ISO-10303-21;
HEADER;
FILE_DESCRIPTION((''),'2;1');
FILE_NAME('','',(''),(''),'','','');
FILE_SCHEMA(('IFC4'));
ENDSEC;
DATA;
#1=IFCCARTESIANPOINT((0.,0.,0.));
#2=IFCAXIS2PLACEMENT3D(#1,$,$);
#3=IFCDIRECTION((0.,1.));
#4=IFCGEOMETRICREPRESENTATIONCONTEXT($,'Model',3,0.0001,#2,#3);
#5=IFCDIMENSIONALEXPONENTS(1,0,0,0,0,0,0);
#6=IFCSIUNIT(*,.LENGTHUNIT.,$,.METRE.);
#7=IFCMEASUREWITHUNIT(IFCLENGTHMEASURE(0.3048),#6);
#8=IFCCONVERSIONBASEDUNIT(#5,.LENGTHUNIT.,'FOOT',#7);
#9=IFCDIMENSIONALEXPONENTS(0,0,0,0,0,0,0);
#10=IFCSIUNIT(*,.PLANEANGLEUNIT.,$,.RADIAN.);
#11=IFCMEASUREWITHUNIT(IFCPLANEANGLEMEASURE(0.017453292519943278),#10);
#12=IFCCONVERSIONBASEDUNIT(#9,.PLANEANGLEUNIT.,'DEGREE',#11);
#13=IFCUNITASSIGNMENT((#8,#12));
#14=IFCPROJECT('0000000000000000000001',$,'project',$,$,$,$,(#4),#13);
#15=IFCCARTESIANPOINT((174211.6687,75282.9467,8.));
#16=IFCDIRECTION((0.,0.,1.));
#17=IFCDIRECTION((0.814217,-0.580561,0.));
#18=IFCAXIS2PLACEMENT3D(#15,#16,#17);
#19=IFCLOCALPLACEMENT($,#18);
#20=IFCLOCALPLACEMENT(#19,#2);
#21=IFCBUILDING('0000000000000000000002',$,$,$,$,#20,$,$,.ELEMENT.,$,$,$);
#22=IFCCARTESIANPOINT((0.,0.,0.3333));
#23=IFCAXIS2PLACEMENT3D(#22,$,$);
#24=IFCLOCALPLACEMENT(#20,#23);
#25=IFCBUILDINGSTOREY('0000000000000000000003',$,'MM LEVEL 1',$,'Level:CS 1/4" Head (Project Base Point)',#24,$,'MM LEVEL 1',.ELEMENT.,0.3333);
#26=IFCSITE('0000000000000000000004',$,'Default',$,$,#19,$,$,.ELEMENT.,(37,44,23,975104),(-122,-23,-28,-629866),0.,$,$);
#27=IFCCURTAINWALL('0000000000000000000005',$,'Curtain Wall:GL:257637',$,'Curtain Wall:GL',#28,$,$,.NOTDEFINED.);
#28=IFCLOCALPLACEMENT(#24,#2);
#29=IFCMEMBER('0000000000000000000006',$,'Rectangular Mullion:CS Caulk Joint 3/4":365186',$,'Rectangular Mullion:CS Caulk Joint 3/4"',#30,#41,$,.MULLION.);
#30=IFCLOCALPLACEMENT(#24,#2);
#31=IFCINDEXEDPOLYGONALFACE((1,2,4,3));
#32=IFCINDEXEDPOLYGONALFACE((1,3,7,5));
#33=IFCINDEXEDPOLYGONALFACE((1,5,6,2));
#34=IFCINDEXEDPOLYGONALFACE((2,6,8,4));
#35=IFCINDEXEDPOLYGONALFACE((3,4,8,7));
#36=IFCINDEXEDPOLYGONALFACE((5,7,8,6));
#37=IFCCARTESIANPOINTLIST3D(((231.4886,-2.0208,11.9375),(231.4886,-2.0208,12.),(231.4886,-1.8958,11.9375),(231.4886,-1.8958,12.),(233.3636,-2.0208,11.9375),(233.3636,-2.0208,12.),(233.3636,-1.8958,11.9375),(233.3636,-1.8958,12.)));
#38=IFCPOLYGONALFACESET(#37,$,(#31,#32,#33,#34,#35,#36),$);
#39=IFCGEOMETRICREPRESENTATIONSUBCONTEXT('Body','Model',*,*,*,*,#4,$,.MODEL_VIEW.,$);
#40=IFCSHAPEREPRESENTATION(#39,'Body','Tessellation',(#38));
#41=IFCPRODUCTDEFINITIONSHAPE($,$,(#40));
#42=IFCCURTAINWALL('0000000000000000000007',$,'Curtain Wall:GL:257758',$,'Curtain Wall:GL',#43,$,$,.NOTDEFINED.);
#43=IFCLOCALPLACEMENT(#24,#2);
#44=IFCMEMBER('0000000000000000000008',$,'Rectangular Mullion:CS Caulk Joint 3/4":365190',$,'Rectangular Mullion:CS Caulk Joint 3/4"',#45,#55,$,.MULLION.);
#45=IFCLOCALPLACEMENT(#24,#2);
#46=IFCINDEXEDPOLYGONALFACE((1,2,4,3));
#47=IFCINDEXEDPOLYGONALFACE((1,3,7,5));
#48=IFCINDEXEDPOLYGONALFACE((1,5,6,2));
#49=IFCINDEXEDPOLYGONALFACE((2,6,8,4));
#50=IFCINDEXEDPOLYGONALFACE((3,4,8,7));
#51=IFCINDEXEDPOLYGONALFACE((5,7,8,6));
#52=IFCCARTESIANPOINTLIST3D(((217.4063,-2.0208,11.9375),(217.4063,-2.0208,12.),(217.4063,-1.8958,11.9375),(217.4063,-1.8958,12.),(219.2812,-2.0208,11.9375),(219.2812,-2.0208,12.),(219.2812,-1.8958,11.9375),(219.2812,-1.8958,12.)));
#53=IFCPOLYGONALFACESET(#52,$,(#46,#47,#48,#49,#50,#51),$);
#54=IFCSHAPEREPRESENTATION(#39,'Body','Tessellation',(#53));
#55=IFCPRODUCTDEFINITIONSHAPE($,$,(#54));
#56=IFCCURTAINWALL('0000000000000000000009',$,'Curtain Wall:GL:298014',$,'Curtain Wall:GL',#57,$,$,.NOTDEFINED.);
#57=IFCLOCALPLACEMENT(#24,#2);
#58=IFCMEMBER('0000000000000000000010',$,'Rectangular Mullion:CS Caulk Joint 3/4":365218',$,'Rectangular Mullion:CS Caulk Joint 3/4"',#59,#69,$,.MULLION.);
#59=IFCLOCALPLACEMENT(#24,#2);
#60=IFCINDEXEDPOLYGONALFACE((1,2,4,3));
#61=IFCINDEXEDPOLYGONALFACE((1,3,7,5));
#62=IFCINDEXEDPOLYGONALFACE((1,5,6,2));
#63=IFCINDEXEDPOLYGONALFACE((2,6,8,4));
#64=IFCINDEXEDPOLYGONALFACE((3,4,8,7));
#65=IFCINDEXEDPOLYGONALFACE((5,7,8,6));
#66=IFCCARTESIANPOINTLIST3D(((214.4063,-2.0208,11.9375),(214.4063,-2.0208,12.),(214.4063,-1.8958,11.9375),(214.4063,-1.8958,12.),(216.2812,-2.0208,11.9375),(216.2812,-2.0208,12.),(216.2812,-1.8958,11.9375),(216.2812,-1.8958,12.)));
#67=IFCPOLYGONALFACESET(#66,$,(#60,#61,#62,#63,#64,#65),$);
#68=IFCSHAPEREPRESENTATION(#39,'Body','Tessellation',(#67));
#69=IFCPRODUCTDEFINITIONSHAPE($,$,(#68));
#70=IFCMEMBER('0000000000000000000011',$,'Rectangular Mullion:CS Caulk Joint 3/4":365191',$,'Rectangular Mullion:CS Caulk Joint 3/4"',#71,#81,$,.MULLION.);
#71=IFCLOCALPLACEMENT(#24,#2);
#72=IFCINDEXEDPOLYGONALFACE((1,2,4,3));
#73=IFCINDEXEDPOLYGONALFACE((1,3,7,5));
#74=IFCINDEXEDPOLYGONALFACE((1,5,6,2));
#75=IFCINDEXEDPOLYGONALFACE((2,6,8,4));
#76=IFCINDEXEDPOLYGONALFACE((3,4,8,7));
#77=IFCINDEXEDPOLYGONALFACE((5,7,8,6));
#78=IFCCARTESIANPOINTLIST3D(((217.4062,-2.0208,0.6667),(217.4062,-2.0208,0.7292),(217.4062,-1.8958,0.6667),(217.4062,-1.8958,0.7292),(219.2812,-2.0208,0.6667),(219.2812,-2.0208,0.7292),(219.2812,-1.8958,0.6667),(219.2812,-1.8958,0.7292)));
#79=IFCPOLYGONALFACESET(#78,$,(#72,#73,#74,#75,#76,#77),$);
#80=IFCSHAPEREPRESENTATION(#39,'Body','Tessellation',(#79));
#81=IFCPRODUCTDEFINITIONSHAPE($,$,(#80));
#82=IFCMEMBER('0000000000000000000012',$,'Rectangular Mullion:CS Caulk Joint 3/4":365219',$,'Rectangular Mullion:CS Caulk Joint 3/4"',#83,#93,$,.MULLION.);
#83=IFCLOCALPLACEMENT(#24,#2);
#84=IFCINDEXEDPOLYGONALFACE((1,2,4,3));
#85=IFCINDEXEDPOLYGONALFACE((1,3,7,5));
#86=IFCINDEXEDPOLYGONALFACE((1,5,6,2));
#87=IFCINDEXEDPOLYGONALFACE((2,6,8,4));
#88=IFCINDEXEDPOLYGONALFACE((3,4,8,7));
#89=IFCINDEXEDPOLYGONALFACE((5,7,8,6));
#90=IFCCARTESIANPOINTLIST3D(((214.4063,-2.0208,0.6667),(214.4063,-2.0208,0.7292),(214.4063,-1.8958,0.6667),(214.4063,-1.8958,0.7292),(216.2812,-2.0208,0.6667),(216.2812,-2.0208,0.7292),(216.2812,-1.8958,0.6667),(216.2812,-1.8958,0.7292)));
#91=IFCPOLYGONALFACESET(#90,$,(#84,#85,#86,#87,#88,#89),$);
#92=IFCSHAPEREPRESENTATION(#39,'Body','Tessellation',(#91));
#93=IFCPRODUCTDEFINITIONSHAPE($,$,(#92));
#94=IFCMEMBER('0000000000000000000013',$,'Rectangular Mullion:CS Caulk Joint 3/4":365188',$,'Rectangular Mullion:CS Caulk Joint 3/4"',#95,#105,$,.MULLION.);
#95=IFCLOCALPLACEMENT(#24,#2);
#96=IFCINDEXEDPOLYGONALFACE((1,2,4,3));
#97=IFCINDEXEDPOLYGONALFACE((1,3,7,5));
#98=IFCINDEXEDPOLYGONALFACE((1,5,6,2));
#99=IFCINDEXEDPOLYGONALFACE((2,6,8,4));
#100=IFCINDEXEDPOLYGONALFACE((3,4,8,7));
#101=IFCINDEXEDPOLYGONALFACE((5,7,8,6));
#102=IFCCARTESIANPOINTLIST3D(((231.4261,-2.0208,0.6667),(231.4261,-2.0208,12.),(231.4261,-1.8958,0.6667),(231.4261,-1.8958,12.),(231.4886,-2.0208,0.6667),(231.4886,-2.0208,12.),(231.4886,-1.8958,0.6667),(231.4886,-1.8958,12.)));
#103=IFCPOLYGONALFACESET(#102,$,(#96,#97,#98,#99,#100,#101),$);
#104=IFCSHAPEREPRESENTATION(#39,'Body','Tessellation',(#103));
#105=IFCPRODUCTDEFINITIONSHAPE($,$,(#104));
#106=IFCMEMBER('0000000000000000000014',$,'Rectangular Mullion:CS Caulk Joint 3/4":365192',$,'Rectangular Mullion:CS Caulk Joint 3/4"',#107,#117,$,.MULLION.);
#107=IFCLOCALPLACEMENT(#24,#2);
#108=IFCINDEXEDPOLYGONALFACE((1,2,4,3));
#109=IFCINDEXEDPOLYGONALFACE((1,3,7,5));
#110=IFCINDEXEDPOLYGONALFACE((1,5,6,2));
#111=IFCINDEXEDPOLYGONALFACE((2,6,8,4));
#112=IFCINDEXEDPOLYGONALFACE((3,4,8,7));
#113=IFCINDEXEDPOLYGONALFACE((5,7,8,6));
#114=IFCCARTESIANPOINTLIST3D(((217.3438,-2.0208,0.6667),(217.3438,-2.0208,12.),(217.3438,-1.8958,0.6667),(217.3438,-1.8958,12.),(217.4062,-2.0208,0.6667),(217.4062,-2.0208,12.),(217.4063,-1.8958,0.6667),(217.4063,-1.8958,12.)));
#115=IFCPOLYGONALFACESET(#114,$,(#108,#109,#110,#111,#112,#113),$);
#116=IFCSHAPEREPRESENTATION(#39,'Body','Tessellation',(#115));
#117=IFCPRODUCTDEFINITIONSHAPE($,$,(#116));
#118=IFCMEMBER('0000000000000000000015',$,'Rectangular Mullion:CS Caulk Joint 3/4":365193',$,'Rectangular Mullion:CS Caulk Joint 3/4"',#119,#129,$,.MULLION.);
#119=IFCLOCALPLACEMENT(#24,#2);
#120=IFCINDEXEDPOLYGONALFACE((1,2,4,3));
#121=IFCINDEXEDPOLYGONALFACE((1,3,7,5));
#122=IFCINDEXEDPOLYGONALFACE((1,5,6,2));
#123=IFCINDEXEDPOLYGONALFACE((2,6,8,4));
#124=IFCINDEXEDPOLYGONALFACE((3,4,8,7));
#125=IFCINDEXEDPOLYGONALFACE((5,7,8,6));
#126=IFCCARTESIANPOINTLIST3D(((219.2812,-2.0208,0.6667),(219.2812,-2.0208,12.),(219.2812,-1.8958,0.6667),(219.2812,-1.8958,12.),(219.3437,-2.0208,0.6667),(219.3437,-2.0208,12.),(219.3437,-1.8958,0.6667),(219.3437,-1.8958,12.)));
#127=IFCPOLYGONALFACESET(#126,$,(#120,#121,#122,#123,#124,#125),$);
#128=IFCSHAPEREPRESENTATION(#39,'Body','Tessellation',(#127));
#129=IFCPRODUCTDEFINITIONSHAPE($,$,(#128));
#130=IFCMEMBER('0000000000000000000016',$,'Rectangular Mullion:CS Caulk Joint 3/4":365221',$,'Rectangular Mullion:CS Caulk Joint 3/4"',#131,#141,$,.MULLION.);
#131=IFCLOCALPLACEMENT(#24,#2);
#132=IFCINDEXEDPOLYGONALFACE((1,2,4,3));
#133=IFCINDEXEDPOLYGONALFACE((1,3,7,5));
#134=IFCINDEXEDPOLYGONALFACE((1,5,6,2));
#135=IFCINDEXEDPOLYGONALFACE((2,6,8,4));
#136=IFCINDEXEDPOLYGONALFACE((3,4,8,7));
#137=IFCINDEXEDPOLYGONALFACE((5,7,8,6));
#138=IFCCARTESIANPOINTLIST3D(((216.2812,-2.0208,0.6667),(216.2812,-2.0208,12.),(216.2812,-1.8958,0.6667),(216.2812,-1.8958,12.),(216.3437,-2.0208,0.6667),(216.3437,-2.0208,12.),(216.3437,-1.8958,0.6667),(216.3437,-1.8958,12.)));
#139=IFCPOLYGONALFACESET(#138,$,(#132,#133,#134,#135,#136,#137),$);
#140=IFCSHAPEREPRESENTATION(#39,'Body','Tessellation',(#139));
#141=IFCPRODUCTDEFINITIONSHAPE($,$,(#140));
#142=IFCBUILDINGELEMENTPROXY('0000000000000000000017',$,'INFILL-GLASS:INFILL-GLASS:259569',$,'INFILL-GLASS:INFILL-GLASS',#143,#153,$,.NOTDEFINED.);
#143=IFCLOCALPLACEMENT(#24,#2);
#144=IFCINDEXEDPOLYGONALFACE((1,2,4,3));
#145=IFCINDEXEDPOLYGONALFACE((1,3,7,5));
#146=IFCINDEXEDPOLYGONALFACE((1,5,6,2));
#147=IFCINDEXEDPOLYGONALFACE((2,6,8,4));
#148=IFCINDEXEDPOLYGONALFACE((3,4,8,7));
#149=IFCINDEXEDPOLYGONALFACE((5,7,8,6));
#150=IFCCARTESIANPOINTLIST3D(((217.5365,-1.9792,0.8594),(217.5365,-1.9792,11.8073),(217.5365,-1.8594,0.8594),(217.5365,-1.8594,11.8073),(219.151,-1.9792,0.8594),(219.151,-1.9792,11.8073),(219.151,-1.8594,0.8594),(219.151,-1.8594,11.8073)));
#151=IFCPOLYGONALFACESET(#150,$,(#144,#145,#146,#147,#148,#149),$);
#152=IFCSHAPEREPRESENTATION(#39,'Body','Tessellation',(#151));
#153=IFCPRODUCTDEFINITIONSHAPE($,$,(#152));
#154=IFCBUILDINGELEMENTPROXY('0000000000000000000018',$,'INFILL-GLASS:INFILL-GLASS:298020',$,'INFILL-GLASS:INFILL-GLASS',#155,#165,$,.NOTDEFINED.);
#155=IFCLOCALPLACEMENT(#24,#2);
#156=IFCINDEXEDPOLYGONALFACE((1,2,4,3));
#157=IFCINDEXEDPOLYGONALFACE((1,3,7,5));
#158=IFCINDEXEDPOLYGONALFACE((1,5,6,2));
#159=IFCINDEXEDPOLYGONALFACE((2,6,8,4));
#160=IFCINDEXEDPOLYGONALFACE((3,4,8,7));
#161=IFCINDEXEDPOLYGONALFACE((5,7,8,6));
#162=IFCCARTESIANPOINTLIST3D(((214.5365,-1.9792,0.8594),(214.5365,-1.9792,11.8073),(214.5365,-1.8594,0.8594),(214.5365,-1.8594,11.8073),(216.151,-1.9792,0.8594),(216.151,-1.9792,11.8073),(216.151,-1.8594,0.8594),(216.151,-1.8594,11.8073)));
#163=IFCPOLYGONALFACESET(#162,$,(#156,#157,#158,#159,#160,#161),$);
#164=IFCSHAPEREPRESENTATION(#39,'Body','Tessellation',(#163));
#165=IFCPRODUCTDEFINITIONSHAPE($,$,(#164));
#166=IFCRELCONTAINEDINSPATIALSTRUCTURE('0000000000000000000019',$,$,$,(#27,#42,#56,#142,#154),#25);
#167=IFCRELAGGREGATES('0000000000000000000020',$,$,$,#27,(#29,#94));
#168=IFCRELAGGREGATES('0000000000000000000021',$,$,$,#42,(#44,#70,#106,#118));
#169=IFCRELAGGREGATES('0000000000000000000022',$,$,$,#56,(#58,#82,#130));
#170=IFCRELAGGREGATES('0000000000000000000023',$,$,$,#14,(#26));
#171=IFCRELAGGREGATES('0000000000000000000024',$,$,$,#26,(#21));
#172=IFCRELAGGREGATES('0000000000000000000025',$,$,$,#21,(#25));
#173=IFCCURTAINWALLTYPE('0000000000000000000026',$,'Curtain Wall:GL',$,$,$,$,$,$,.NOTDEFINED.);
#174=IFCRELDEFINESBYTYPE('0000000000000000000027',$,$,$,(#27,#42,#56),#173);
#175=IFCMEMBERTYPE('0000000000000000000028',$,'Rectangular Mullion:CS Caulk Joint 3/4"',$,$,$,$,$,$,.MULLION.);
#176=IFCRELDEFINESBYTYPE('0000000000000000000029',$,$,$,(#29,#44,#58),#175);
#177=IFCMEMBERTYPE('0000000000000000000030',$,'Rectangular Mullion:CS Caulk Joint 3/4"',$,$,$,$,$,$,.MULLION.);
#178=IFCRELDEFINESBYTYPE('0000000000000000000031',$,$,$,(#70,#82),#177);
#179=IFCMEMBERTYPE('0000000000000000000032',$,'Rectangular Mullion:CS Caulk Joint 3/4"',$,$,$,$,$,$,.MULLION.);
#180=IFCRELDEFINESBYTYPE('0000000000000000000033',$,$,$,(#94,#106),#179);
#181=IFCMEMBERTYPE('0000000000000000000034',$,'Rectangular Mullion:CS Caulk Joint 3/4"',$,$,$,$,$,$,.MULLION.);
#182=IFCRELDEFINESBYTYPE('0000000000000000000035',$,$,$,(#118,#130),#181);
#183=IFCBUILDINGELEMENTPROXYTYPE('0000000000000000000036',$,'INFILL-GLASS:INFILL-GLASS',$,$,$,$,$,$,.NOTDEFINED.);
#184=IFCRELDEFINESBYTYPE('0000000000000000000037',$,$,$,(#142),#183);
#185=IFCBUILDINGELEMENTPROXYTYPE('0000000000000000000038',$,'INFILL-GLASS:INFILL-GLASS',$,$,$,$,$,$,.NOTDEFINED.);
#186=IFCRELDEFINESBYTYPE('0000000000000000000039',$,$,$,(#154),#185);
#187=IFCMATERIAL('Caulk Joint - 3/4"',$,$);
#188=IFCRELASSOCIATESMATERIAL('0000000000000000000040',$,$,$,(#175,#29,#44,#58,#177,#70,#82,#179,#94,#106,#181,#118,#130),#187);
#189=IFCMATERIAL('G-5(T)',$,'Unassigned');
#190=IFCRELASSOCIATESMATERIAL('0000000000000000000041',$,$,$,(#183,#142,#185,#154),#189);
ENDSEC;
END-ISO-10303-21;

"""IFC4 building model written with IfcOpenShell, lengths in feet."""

from ifc_helpers import new_model, entity, si_unit, converted_unit, direction, frame, origin, place, context, subcontext, project, spatial, indexed_curve, outline, extrude, source, transform, mapped, material, type_object, type_shapes, element, aggregate, save


model = new_model("IFC4")

# Units and contexts
model_context = context("Model", 3, precision=0.0001, world=origin(), true_north=direction((0.0, 1.0)))
body_context = subcontext(model_context, "Body", "Model", "MODEL_VIEW")
ifc_project = project(units=[converted_unit("LENGTHUNIT", "FOOT", entity("IfcLengthMeasure", 0.3048), si_unit("LENGTHUNIT", "METRE"), dimensions=[1, 0, 0, 0, 0, 0, 0]), converted_unit("PLANEANGLEUNIT", "DEGREE", entity("IfcPlaneAngleMeasure", 0.017453292519943278), si_unit("PLANEANGLEUNIT", "RADIAN"), dimensions=[0, 0, 0, 0, 0, 0, 0])], contexts=[model_context])

# Site, building, storey
site_placement = place(None, frame((174211.6687, 75282.9467, 8.0), z_axis=(0.0, 0.0, 1.0), x_axis=(0.814217, -0.580561, 0.0)))
site = spatial("IfcSite", under=ifc_project, at=site_placement, Name="Default", CompositionType="ELEMENT", RefLatitude=(37, 44, 23, 975104), RefLongitude=(-122, -23, -28, -629866), RefElevation=0.0)
building_placement = place(site_placement, origin())
building = spatial("IfcBuilding", under=site, at=building_placement, CompositionType="ELEMENT")
storey_placement = place(building_placement, frame((0.0, 0.0, 0.3333)))
storey = spatial("IfcBuildingStorey", under=building, at=storey_placement, Name="MM LEVEL 1", ObjectType="Level:CS 1/4\" Head (Project Base Point)", LongName="MM LEVEL 1", CompositionType="ELEMENT", Elevation=0.3333)

# Curtain walls, members
curtain_wall_type = type_object("IfcCurtainWallType", Name="Curtain Wall:GL", PredefinedType="NOTDEFINED")
curtain_wall_1_placement = place(storey_placement, frame((0.0, 0.0, -0.3333)))
curtain_wall_1 = element("IfcCurtainWall", 1, at=curtain_wall_1_placement, inside=storey, type_object=curtain_wall_type, Name="Curtain Wall:GL:257637", ObjectType="Curtain Wall:GL", PredefinedType="NOTDEFINED")
ifc_material_1 = material(Name="Caulk Joint - 3/4\"")
member_type_1 = type_object("IfcMemberType", Name="Rectangular Mullion:CS Caulk Joint 3/4\"", PredefinedType="MULLION", material=ifc_material_1)
shared_shape_1 = source(origin(), body_context, "Body", "SweptSolid", [
    extrude(outline(indexed_curve([(-0.0625, -0.0312), (0.0625, -0.0312), (0.0625, 0.0312), (-0.0625, 0.0312), (-0.0625, -0.0312)], self_intersect=False)), frame((-0.0312, 0.0625, -1.875), z_axis=(0.0, 0.0, 1.0), x_axis=(0.0, -1.0, 0.0)), (0.0, 0.0, 1.0), 1.875),
])
type_shapes(member_type_1, [shared_shape_1])
member_1_placement = place(curtain_wall_1_placement, frame((231.4886, -2.0208, 12.3333), z_axis=(-1.0, 0.0, 0.0), x_axis=(0.0, 0.0, 1.0)))
member_1 = element("IfcMember", 2, at=member_1_placement, type_object=member_type_1, material=ifc_material_1, Name="Rectangular Mullion:CS Caulk Joint 3/4\":365186", ObjectType="Rectangular Mullion:CS Caulk Joint 3/4\"", PredefinedType="MULLION", context=body_context, shape_type="MappedRepresentation", body=[
    mapped(shared_shape_1, transform((0.0, 0.0, 0.0), scale=1.0)),
])
curtain_wall_2_placement = place(storey_placement, frame((0.0, 0.0, -0.3333)))
curtain_wall_2 = element("IfcCurtainWall", 3, at=curtain_wall_2_placement, inside=storey, type_object=curtain_wall_type, Name="Curtain Wall:GL:257758", ObjectType="Curtain Wall:GL", PredefinedType="NOTDEFINED")
member_2_placement = place(curtain_wall_2_placement, frame((217.4063, -2.0208, 12.3333), z_axis=(-1.0, 0.0, 0.0), x_axis=(0.0, 0.0, 1.0)))
member_2 = element("IfcMember", 4, at=member_2_placement, type_object=member_type_1, material=ifc_material_1, Name="Rectangular Mullion:CS Caulk Joint 3/4\":365190", ObjectType="Rectangular Mullion:CS Caulk Joint 3/4\"", PredefinedType="MULLION", context=body_context, shape_type="MappedRepresentation", body=[
    mapped(shared_shape_1, transform((0.0, 0.0, 0.0), scale=1.0)),
])
curtain_wall_3_placement = place(storey_placement, frame((0.0, 0.0, -0.3333)))
curtain_wall_3 = element("IfcCurtainWall", 5, at=curtain_wall_3_placement, inside=storey, type_object=curtain_wall_type, Name="Curtain Wall:GL:298014", ObjectType="Curtain Wall:GL", PredefinedType="NOTDEFINED")
member_3_placement = place(curtain_wall_3_placement, frame((214.4062, -2.0208, 12.3333), z_axis=(-1.0, 0.0, 0.0), x_axis=(0.0, 0.0, 1.0)))
member_3 = element("IfcMember", 6, at=member_3_placement, type_object=member_type_1, material=ifc_material_1, Name="Rectangular Mullion:CS Caulk Joint 3/4\":365218", ObjectType="Rectangular Mullion:CS Caulk Joint 3/4\"", PredefinedType="MULLION", context=body_context, shape_type="MappedRepresentation", body=[
    mapped(shared_shape_1, transform((0.0, 0.0, 0.0), scale=1.0)),
])

# Members
member_type_2 = type_object("IfcMemberType", Name="Rectangular Mullion:CS Caulk Joint 3/4\"", PredefinedType="MULLION", material=ifc_material_1)
shared_shape_2 = source(origin(), body_context, "Body", "SweptSolid", [
    extrude(outline(indexed_curve([(-0.0312, -0.0625), (0.0312, -0.0625), (0.0312, 0.0625), (-0.0312, 0.0625), (-0.0312, -0.0625)], self_intersect=False)), frame((-0.0312, 0.0625, -1.875), z_axis=(0.0, 0.0, 1.0), x_axis=(-1.0, 0.0, 0.0)), (0.0, 0.0, 1.0), 1.875),
])
type_shapes(member_type_2, [shared_shape_2])
member_4_placement = place(curtain_wall_2_placement, frame((219.2812, -2.0208, 1.0), z_axis=(1.0, 0.0, 0.0), x_axis=(0.0, 0.0, -1.0)))
member_4 = element("IfcMember", 7, at=member_4_placement, type_object=member_type_2, material=ifc_material_1, Name="Rectangular Mullion:CS Caulk Joint 3/4\":365191", ObjectType="Rectangular Mullion:CS Caulk Joint 3/4\"", PredefinedType="MULLION", context=body_context, shape_type="MappedRepresentation", body=[
    mapped(shared_shape_2, transform((0.0, 0.0, 0.0), scale=1.0)),
])
member_5_placement = place(curtain_wall_3_placement, frame((216.2812, -2.0208, 1.0), z_axis=(1.0, 0.0, 0.0), x_axis=(0.0, 0.0, -1.0)))
member_5 = element("IfcMember", 8, at=member_5_placement, type_object=member_type_2, material=ifc_material_1, Name="Rectangular Mullion:CS Caulk Joint 3/4\":365219", ObjectType="Rectangular Mullion:CS Caulk Joint 3/4\"", PredefinedType="MULLION", context=body_context, shape_type="MappedRepresentation", body=[
    mapped(shared_shape_2, transform((0.0, 0.0, 0.0), scale=1.0)),
])
member_type_3 = type_object("IfcMemberType", Name="Rectangular Mullion:CS Caulk Joint 3/4\"", PredefinedType="MULLION", material=ifc_material_1)
shared_shape_3 = source(origin(), body_context, "Body", "SweptSolid", [
    extrude(outline(indexed_curve([(-0.0625, -0.0312), (0.0625, -0.0312), (0.0625, 0.0312), (-0.0625, 0.0312), (-0.0625, -0.0312)], self_intersect=False)), frame((-0.0312, 0.0625, -11.3333), z_axis=(0.0, 0.0, 1.0), x_axis=(0.0, -1.0, 0.0)), (0.0, 0.0, 1.0), 11.3333),
])
type_shapes(member_type_3, [shared_shape_3])
member_6_placement = place(curtain_wall_1_placement, frame((231.4261, -2.0208, 1.0), z_axis=(0.0, 0.0, -1.0), x_axis=(-1.0, 0.0, 0.0)))
member_6 = element("IfcMember", 9, at=member_6_placement, type_object=member_type_3, material=ifc_material_1, Name="Rectangular Mullion:CS Caulk Joint 3/4\":365188", ObjectType="Rectangular Mullion:CS Caulk Joint 3/4\"", PredefinedType="MULLION", context=body_context, shape_type="MappedRepresentation", body=[
    mapped(shared_shape_3, transform((0.0, 0.0, 0.0), scale=1.0)),
])
aggregate(curtain_wall_1, [member_1, member_6])
member_7_placement = place(curtain_wall_2_placement, frame((217.3438, -2.0208, 1.0), z_axis=(0.0, 0.0, -1.0), x_axis=(-1.0, 0.0, 0.0)))
member_7 = element("IfcMember", 10, at=member_7_placement, type_object=member_type_3, material=ifc_material_1, Name="Rectangular Mullion:CS Caulk Joint 3/4\":365192", ObjectType="Rectangular Mullion:CS Caulk Joint 3/4\"", PredefinedType="MULLION", context=body_context, shape_type="MappedRepresentation", body=[
    mapped(shared_shape_3, transform((0.0, 0.0, 0.0), scale=1.0)),
])
member_type_4 = type_object("IfcMemberType", Name="Rectangular Mullion:CS Caulk Joint 3/4\"", PredefinedType="MULLION", material=ifc_material_1)
shared_shape_4 = source(origin(), body_context, "Body", "SweptSolid", [
    extrude(outline(indexed_curve([(-0.0312, -0.0625), (0.0312, -0.0625), (0.0312, 0.0625), (-0.0312, 0.0625), (-0.0312, -0.0625)], self_intersect=False)), frame((-0.0312, 0.0625, -11.3333), z_axis=(0.0, 0.0, 1.0), x_axis=(-1.0, 0.0, 0.0)), (0.0, 0.0, 1.0), 11.3333),
])
type_shapes(member_type_4, [shared_shape_4])
member_8_placement = place(curtain_wall_2_placement, frame((219.3437, -2.0208, 12.3333)))
member_8 = element("IfcMember", 11, at=member_8_placement, type_object=member_type_4, material=ifc_material_1, Name="Rectangular Mullion:CS Caulk Joint 3/4\":365193", ObjectType="Rectangular Mullion:CS Caulk Joint 3/4\"", PredefinedType="MULLION", context=body_context, shape_type="MappedRepresentation", body=[
    mapped(shared_shape_4, transform((0.0, 0.0, 0.0), scale=1.0)),
])
aggregate(curtain_wall_2, [member_2, member_4, member_7, member_8])
member_9_placement = place(curtain_wall_3_placement, frame((216.3437, -2.0208, 12.3333)))
member_9 = element("IfcMember", 12, at=member_9_placement, type_object=member_type_4, material=ifc_material_1, Name="Rectangular Mullion:CS Caulk Joint 3/4\":365221", ObjectType="Rectangular Mullion:CS Caulk Joint 3/4\"", PredefinedType="MULLION", context=body_context, shape_type="MappedRepresentation", body=[
    mapped(shared_shape_4, transform((0.0, 0.0, 0.0), scale=1.0)),
])
aggregate(curtain_wall_3, [member_3, member_5, member_9])

# Building element proxies
ifc_material_2 = material(Name="G-5(T)", Category="Unassigned")
building_element_proxy_type_1 = type_object("IfcBuildingElementProxyType", Name="INFILL-GLASS:INFILL-GLASS", PredefinedType="NOTDEFINED", material=ifc_material_2)
shared_shape_5 = source(origin(), body_context, "Body", "SweptSolid", [
    extrude(outline(indexed_curve([(-0.0599, -0.8073), (0.0599, -0.8073), (0.0599, 0.8073), (-0.0599, 0.8073), (-0.0599, -0.8073)], self_intersect=False)), frame((0.0, 0.1016, 0.1302), z_axis=(0.0, 0.0, 1.0), x_axis=(0.0, 1.0, 0.0)), (0.0, 0.0, 1.0), 10.9479),
])
type_shapes(building_element_proxy_type_1, [shared_shape_5])
proxy_1_placement = place(storey_placement, frame((218.3437, -2.0208, 0.7292)))
element("IfcBuildingElementProxy", 13, at=proxy_1_placement, inside=storey, type_object=building_element_proxy_type_1, material=ifc_material_2, Name="INFILL-GLASS:INFILL-GLASS:259569", ObjectType="INFILL-GLASS:INFILL-GLASS", PredefinedType="NOTDEFINED", context=body_context, shape_type="MappedRepresentation", body=[
    mapped(shared_shape_5, transform((0.0, 0.0, 0.0), scale=1.0)),
])
building_element_proxy_type_2 = type_object("IfcBuildingElementProxyType", Name="INFILL-GLASS:INFILL-GLASS", PredefinedType="NOTDEFINED", material=ifc_material_2)
shared_shape_6 = source(origin(), body_context, "Body", "SweptSolid", [
    extrude(outline(indexed_curve([(-0.0599, -0.8073), (0.0599, -0.8073), (0.0599, 0.8073), (-0.0599, 0.8073), (-0.0599, -0.8073)], self_intersect=False)), frame((0.0, 0.1016, 0.1302), z_axis=(0.0, 0.0, 1.0), x_axis=(0.0, 1.0, 0.0)), (0.0, 0.0, 1.0), 10.9479),
])
type_shapes(building_element_proxy_type_2, [shared_shape_6])
proxy_2_placement = place(storey_placement, frame((215.3437, -2.0208, 0.7292)))
element("IfcBuildingElementProxy", 14, at=proxy_2_placement, inside=storey, type_object=building_element_proxy_type_2, material=ifc_material_2, Name="INFILL-GLASS:INFILL-GLASS:298020", ObjectType="INFILL-GLASS:INFILL-GLASS", PredefinedType="NOTDEFINED", context=body_context, shape_type="MappedRepresentation", body=[
    mapped(shared_shape_6, transform((0.0, 0.0, 0.0), scale=1.0)),
])

save(model, "model.ifc")
